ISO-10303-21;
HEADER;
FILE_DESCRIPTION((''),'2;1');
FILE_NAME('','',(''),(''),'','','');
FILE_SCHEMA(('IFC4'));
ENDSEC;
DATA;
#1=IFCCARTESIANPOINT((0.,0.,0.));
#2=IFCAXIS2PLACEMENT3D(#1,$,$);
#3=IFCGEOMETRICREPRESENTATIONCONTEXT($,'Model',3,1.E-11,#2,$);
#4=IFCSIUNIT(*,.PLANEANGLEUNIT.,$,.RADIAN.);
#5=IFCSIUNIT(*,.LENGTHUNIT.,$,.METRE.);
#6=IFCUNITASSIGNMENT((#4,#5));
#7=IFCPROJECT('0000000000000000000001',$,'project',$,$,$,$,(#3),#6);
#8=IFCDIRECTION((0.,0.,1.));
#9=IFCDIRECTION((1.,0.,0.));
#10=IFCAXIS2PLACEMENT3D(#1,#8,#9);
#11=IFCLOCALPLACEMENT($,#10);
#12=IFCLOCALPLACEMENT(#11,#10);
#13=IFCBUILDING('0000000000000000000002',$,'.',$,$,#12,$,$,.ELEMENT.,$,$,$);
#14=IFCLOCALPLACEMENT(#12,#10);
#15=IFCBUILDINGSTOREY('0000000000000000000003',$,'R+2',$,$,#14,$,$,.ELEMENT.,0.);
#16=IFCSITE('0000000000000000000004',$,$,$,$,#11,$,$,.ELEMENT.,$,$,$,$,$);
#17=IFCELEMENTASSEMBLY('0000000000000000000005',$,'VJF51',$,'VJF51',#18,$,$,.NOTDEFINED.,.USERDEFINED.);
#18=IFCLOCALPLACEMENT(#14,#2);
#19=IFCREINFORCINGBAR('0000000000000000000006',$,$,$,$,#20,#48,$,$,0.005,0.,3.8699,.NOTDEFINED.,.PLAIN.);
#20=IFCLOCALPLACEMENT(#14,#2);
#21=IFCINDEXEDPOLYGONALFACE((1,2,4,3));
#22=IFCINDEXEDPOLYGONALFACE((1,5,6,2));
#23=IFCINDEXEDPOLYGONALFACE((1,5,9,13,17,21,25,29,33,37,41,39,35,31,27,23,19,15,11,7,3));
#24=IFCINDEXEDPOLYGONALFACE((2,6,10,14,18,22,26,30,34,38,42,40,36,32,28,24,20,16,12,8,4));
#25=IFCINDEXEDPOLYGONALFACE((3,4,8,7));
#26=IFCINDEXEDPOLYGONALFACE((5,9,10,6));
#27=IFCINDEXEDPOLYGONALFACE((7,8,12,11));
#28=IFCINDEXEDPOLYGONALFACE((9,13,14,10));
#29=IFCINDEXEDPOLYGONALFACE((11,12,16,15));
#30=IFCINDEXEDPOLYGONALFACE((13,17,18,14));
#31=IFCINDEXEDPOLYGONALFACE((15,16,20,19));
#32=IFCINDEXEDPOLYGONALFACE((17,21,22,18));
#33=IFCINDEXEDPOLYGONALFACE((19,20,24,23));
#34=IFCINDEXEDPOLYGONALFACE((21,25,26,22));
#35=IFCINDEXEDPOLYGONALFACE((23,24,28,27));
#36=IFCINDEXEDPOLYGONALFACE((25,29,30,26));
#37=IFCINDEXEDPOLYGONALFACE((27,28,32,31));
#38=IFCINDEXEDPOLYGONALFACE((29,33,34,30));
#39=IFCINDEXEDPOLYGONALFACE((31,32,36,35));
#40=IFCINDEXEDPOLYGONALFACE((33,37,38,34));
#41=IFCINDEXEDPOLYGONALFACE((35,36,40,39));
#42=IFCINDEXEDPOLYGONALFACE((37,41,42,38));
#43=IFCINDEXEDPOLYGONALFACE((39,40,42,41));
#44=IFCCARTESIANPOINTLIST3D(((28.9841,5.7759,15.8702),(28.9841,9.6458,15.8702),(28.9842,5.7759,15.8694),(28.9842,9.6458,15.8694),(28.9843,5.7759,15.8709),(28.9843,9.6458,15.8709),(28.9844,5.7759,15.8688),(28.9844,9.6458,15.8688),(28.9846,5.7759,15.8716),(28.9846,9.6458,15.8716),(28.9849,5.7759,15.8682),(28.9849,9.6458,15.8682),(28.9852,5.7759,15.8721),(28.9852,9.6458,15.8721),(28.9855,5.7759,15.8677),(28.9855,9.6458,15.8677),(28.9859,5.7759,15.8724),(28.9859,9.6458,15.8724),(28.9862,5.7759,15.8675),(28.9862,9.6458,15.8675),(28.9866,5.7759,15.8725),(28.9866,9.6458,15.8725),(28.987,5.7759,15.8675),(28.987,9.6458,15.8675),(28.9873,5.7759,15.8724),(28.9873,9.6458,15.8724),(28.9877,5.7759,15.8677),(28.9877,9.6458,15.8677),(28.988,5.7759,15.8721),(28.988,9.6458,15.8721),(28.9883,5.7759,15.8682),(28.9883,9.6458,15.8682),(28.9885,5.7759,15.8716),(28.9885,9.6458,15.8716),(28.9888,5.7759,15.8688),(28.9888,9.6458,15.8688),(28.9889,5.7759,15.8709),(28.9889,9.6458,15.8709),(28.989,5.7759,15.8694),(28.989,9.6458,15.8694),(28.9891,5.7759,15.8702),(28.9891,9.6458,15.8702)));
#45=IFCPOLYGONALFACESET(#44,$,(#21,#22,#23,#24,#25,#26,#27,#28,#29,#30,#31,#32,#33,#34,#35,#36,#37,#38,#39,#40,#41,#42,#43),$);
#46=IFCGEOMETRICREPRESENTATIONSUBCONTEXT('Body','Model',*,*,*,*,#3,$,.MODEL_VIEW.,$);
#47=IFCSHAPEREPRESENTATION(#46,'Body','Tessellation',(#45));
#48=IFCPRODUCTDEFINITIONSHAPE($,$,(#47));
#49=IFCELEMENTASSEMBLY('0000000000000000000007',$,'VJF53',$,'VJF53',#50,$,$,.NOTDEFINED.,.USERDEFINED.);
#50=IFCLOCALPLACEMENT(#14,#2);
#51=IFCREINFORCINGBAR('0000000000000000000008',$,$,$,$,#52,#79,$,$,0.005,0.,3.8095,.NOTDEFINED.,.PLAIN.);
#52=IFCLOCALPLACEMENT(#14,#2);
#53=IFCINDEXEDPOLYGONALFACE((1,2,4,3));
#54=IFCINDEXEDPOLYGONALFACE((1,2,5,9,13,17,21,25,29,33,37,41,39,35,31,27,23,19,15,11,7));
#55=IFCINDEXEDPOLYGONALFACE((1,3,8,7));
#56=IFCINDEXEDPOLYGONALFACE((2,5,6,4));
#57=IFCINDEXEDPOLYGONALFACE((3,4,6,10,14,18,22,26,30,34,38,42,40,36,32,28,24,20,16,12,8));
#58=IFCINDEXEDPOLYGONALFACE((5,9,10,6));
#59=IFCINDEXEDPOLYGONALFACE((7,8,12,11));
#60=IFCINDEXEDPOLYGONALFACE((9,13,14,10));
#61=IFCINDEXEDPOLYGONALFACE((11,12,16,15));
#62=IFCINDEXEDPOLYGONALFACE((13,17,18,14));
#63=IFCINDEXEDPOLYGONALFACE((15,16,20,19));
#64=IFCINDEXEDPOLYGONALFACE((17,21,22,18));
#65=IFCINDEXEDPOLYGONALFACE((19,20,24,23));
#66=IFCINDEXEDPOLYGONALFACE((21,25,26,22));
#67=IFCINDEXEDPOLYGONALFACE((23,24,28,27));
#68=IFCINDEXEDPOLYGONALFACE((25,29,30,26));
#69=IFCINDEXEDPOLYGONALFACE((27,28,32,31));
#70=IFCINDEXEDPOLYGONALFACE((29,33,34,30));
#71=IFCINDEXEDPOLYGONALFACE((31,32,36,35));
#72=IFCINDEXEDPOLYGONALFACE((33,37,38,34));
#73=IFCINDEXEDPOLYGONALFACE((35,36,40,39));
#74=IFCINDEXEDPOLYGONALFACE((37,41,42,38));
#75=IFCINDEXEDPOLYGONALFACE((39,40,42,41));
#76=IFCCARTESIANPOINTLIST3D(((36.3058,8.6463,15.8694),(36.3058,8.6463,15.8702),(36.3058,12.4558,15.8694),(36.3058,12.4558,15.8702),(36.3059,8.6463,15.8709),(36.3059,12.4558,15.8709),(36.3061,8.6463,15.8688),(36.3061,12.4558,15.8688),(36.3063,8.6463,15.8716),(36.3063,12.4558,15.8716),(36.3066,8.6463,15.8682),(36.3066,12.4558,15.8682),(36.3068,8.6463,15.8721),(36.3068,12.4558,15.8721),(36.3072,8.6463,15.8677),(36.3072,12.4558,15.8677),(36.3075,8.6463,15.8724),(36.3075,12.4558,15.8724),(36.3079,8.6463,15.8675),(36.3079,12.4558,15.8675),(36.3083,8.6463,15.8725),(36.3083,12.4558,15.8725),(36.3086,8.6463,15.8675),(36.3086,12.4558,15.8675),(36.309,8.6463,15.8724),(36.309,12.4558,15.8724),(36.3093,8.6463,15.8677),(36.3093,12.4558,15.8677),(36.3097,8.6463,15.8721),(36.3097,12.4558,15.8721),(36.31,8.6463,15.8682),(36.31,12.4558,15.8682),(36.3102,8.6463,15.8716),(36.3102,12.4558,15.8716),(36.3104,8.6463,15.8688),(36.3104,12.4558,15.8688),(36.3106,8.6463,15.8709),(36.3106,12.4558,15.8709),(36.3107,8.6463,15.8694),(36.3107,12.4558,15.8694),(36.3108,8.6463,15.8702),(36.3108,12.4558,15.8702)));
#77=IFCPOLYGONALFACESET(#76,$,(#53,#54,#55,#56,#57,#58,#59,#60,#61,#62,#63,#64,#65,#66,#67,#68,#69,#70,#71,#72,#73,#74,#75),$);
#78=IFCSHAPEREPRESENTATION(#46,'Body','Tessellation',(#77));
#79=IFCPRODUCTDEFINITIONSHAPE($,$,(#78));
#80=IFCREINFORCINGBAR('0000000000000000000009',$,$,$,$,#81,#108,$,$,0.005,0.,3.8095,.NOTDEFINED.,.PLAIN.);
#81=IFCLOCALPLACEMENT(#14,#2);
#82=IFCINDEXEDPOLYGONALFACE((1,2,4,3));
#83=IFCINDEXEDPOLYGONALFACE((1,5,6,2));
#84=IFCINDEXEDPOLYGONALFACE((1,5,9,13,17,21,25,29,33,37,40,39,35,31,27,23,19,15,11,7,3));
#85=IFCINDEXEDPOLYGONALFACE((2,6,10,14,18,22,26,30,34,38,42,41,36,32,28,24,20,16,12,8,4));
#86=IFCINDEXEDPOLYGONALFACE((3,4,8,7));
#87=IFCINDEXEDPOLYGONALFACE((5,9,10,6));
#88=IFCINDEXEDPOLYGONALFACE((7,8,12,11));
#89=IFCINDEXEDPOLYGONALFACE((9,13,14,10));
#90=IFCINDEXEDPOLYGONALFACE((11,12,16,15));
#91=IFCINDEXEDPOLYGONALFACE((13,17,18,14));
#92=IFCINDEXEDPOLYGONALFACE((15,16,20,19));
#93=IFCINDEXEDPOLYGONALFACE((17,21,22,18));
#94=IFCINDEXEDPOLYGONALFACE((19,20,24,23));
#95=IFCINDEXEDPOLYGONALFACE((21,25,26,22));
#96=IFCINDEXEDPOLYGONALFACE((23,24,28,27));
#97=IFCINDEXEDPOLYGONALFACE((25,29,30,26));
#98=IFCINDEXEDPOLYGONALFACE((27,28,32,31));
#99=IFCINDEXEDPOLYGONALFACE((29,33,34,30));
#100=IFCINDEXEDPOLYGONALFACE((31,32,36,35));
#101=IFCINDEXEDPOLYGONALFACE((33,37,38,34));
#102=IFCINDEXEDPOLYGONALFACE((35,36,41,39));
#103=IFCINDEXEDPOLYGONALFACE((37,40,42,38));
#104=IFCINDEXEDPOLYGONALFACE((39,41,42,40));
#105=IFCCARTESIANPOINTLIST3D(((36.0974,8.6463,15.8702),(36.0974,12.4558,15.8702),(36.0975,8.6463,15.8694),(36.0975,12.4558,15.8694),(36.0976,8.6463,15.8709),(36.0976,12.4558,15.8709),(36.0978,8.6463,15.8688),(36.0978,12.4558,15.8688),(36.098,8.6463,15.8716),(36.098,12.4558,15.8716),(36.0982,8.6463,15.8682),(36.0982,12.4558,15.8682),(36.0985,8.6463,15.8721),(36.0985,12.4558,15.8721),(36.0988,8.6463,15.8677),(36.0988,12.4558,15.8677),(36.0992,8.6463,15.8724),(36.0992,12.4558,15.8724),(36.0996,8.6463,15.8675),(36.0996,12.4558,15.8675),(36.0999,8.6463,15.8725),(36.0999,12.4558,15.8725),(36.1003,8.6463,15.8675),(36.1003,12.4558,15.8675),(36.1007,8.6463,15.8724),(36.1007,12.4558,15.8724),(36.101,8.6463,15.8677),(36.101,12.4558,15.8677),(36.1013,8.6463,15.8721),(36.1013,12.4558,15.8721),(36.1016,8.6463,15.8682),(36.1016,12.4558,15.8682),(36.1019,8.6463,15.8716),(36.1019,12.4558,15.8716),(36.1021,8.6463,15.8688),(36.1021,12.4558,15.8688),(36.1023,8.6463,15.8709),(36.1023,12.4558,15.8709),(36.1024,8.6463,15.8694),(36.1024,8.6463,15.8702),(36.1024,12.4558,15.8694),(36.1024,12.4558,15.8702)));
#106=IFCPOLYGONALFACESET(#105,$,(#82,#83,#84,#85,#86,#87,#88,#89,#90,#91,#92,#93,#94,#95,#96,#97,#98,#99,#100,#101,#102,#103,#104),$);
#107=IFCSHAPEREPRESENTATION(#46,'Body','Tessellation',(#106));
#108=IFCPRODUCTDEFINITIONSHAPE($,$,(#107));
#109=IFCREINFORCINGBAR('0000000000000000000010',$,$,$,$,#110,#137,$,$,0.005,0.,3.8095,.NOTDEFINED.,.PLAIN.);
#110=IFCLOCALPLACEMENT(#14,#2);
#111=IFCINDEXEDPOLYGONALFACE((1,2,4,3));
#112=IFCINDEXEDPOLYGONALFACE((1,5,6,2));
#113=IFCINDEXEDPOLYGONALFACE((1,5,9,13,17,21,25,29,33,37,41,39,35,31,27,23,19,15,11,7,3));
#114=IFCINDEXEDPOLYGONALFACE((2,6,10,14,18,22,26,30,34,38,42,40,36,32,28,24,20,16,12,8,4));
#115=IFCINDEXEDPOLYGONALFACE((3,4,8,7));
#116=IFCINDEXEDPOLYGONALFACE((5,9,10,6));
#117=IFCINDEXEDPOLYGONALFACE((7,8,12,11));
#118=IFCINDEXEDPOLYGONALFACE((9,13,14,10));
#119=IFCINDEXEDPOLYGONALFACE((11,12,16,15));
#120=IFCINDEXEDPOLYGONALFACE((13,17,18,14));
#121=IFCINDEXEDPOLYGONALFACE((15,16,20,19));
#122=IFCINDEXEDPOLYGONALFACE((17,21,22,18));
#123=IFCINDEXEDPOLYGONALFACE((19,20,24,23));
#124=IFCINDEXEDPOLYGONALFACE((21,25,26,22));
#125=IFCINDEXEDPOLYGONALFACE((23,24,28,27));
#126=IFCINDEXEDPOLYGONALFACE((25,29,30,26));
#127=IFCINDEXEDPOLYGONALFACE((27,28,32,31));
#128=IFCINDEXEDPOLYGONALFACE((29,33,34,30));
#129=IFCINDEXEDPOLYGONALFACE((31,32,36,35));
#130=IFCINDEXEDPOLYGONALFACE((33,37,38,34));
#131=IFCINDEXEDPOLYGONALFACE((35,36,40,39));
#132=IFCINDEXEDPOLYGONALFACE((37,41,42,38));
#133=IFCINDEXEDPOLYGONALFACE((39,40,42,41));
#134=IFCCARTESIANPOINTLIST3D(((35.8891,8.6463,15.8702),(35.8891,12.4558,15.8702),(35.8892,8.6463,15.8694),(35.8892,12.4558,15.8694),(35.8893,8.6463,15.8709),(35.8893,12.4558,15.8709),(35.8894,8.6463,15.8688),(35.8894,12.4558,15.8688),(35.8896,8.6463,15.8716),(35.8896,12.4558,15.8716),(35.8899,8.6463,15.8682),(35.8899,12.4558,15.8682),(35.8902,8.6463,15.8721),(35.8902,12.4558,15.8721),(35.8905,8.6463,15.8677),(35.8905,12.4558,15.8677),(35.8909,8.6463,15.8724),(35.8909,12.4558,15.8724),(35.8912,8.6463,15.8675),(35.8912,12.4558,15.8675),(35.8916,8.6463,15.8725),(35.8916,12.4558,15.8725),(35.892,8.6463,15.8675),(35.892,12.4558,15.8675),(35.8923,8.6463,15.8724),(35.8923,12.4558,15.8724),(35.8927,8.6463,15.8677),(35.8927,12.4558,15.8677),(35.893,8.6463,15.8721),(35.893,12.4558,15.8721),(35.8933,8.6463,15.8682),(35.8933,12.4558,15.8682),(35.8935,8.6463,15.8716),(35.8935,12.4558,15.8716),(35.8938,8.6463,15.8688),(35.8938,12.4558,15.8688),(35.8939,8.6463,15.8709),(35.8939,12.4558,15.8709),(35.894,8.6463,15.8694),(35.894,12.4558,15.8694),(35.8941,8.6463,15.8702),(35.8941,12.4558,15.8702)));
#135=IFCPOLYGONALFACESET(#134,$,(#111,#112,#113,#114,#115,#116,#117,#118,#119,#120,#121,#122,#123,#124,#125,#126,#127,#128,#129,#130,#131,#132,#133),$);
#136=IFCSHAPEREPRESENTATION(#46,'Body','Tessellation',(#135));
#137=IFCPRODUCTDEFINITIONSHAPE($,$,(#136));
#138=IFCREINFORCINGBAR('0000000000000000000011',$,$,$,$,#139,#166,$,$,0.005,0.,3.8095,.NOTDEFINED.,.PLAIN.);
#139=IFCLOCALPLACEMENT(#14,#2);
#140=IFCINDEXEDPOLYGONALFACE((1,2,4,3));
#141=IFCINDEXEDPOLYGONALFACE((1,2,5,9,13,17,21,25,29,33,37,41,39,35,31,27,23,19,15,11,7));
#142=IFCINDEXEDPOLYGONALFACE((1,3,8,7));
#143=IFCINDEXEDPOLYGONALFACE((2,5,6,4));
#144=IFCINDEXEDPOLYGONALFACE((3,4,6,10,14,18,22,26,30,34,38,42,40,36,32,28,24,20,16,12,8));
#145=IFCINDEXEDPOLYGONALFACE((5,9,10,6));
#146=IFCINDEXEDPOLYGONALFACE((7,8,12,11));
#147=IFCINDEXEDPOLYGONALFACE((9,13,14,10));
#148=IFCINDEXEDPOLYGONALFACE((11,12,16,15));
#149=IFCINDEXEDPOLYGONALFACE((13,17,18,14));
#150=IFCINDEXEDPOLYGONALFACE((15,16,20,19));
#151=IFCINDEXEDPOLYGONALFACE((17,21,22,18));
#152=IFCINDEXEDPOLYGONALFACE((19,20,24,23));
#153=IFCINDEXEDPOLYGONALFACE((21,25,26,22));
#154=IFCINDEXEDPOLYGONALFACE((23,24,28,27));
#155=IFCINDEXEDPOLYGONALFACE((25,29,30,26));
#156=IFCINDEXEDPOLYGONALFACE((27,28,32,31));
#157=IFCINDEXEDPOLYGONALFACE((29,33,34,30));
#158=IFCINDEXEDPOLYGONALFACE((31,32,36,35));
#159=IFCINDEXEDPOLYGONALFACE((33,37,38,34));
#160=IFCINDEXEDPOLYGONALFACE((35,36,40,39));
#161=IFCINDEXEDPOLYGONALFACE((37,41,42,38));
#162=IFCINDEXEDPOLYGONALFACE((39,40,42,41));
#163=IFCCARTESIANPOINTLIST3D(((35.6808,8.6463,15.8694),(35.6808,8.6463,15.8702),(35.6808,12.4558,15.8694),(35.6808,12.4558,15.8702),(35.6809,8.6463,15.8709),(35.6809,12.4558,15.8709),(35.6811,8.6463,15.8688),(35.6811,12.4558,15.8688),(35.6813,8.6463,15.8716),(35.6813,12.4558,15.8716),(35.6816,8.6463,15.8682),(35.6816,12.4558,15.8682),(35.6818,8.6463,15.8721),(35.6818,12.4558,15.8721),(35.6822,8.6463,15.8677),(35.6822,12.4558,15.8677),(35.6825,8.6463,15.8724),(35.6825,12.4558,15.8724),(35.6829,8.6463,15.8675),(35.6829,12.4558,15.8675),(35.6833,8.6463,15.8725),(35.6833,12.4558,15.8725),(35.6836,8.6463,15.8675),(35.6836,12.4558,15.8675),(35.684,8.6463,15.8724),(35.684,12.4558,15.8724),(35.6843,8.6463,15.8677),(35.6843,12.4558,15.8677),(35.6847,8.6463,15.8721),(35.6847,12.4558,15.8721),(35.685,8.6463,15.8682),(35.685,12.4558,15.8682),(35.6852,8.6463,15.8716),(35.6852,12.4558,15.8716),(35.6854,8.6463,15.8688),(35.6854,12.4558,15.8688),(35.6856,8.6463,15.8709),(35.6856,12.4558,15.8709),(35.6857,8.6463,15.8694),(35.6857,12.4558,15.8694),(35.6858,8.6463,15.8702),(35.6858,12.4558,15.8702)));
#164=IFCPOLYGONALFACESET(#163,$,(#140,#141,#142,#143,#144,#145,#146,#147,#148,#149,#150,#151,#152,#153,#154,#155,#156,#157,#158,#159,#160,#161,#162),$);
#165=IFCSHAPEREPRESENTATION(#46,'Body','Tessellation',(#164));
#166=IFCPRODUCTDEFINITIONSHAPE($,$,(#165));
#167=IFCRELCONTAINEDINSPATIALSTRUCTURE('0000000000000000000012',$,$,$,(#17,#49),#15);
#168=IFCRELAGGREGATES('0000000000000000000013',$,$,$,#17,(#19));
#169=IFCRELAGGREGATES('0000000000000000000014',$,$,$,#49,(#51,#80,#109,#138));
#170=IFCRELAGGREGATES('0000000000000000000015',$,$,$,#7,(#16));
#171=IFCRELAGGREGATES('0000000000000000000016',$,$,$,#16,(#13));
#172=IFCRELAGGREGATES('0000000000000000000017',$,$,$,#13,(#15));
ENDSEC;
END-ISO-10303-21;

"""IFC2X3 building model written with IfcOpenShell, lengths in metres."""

from ifc_helpers import new_model, entity, si_unit, origin, origin_with_axes, place, context, subcontext, project, spatial, shape, element, aggregate, save


model = new_model("IFC2X3")

# Units and contexts
model_context = context("Model", 3, precision=1e-11, world=origin())
body_context = subcontext(model_context, "Body", "Model", "MODEL_VIEW")
ifc_project = project(units=[si_unit("PLANEANGLEUNIT", "RADIAN"), si_unit("LENGTHUNIT", "METRE")], contexts=[model_context])

# Site, building, storey
site_placement = place(None, origin_with_axes())
site = spatial("IfcSite", under=ifc_project, at=site_placement, CompositionType="ELEMENT")
building_placement = place(site_placement, origin_with_axes())
building = spatial("IfcBuilding", under=site, at=building_placement, Name=".", CompositionType="ELEMENT")
storey_placement = place(building_placement, origin_with_axes())
storey = spatial("IfcBuildingStorey", under=building, at=storey_placement, Name="R+2", CompositionType="ELEMENT", Elevation=0.0)

# Element assembly, reinforcing bar
assembly_1_placement = place(storey_placement, origin_with_axes())
assembly_1 = element("IfcElementAssembly", 1, at=assembly_1_placement, inside=storey, Name="VJF51", ObjectType="VJF51", AssemblyPlace="NOTDEFINED", PredefinedType="USERDEFINED")
reinforcing_bar_1_placement = place(assembly_1_placement, origin_with_axes())
reinforcing_bar_1 = element("IfcReinforcingBar", 2, at=reinforcing_bar_1_placement, BarLength=3.8699, BarRole="NOTDEFINED", BarSurface="PLAIN", CrossSectionArea=0.0, NominalDiameter=0.005, shapes=[
    shape(body_context, "Body", "AdvancedSweptSolid", [entity("IfcSweptDiskSolid", entity("IfcPolyline", [entity("IfcCartesianPoint", [28.9866, 5.7759, 15.87]), entity("IfcCartesianPoint", [28.9866, 9.6458, 15.87])]), 0.0025, None, 0.0, 3.8699)]),
    shape(body_context, "Body", "AdvancedSweptSolid", [entity("IfcSweptDiskSolid", entity("IfcPolyline", [entity("IfcCartesianPoint", [28.9866, 5.7759, 15.87]), entity("IfcCartesianPoint", [28.9866, 9.6458, 15.87])]), 0.0025, None, 0.0, 3.8699)]),
])
aggregate(assembly_1, [reinforcing_bar_1])

# Element assembly, reinforcing bars
assembly_2_placement = place(storey_placement, origin_with_axes())
assembly_2 = element("IfcElementAssembly", 3, at=assembly_2_placement, inside=storey, Name="VJF53", ObjectType="VJF53", AssemblyPlace="NOTDEFINED", PredefinedType="USERDEFINED")
reinforcing_bar_2_placement = place(assembly_2_placement, origin_with_axes())
reinforcing_bar_2 = element("IfcReinforcingBar", 4, at=reinforcing_bar_2_placement, BarLength=3.8095, BarRole="NOTDEFINED", BarSurface="PLAIN", CrossSectionArea=0.0, NominalDiameter=0.005, shapes=[
    shape(body_context, "Body", "AdvancedSweptSolid", [entity("IfcSweptDiskSolid", entity("IfcPolyline", [entity("IfcCartesianPoint", [36.3083, 8.6463, 15.87]), entity("IfcCartesianPoint", [36.3083, 12.4558, 15.87])]), 0.0025, None, 0.0, 3.8095)]),
    shape(body_context, "Body", "AdvancedSweptSolid", [entity("IfcSweptDiskSolid", entity("IfcPolyline", [entity("IfcCartesianPoint", [36.3083, 8.6463, 15.87]), entity("IfcCartesianPoint", [36.3083, 12.4558, 15.87])]), 0.0025, None, 0.0, 3.8095)]),
])
reinforcing_bar_3_placement = place(assembly_2_placement, origin_with_axes())
reinforcing_bar_3 = element("IfcReinforcingBar", 5, at=reinforcing_bar_3_placement, BarLength=3.8095, BarRole="NOTDEFINED", BarSurface="PLAIN", CrossSectionArea=0.0, NominalDiameter=0.005, shapes=[
    shape(body_context, "Body", "AdvancedSweptSolid", [entity("IfcSweptDiskSolid", entity("IfcPolyline", [entity("IfcCartesianPoint", [36.0999, 8.6463, 15.87]), entity("IfcCartesianPoint", [36.0999, 12.4558, 15.87])]), 0.0025, None, 0.0, 3.8095)]),
    shape(body_context, "Body", "AdvancedSweptSolid", [entity("IfcSweptDiskSolid", entity("IfcPolyline", [entity("IfcCartesianPoint", [36.0999, 8.6463, 15.87]), entity("IfcCartesianPoint", [36.0999, 12.4558, 15.87])]), 0.0025, None, 0.0, 3.8095)]),
])
reinforcing_bar_4_placement = place(assembly_2_placement, origin_with_axes())
reinforcing_bar_4 = element("IfcReinforcingBar", 6, at=reinforcing_bar_4_placement, BarLength=3.8095, BarRole="NOTDEFINED", BarSurface="PLAIN", CrossSectionArea=0.0, NominalDiameter=0.005, shapes=[
    shape(body_context, "Body", "AdvancedSweptSolid", [entity("IfcSweptDiskSolid", entity("IfcPolyline", [entity("IfcCartesianPoint", [35.8916, 8.6463, 15.87]), entity("IfcCartesianPoint", [35.8916, 12.4558, 15.87])]), 0.0025, None, 0.0, 3.8095)]),
    shape(body_context, "Body", "AdvancedSweptSolid", [entity("IfcSweptDiskSolid", entity("IfcPolyline", [entity("IfcCartesianPoint", [35.8916, 8.6463, 15.87]), entity("IfcCartesianPoint", [35.8916, 12.4558, 15.87])]), 0.0025, None, 0.0, 3.8095)]),
])
reinforcing_bar_5_placement = place(assembly_2_placement, origin_with_axes())
reinforcing_bar_5 = element("IfcReinforcingBar", 7, at=reinforcing_bar_5_placement, BarLength=3.8095, BarRole="NOTDEFINED", BarSurface="PLAIN", CrossSectionArea=0.0, NominalDiameter=0.005, shapes=[
    shape(body_context, "Body", "AdvancedSweptSolid", [entity("IfcSweptDiskSolid", entity("IfcPolyline", [entity("IfcCartesianPoint", [35.6833, 8.6463, 15.87]), entity("IfcCartesianPoint", [35.6833, 12.4558, 15.87])]), 0.0025, None, 0.0, 3.8095)]),
    shape(body_context, "Body", "AdvancedSweptSolid", [entity("IfcSweptDiskSolid", entity("IfcPolyline", [entity("IfcCartesianPoint", [35.6833, 8.6463, 15.87]), entity("IfcCartesianPoint", [35.6833, 12.4558, 15.87])]), 0.0025, None, 0.0, 3.8095)]),
])
aggregate(assembly_2, [reinforcing_bar_2, reinforcing_bar_3, reinforcing_bar_4, reinforcing_bar_5])

save(model, "model.ifc")
